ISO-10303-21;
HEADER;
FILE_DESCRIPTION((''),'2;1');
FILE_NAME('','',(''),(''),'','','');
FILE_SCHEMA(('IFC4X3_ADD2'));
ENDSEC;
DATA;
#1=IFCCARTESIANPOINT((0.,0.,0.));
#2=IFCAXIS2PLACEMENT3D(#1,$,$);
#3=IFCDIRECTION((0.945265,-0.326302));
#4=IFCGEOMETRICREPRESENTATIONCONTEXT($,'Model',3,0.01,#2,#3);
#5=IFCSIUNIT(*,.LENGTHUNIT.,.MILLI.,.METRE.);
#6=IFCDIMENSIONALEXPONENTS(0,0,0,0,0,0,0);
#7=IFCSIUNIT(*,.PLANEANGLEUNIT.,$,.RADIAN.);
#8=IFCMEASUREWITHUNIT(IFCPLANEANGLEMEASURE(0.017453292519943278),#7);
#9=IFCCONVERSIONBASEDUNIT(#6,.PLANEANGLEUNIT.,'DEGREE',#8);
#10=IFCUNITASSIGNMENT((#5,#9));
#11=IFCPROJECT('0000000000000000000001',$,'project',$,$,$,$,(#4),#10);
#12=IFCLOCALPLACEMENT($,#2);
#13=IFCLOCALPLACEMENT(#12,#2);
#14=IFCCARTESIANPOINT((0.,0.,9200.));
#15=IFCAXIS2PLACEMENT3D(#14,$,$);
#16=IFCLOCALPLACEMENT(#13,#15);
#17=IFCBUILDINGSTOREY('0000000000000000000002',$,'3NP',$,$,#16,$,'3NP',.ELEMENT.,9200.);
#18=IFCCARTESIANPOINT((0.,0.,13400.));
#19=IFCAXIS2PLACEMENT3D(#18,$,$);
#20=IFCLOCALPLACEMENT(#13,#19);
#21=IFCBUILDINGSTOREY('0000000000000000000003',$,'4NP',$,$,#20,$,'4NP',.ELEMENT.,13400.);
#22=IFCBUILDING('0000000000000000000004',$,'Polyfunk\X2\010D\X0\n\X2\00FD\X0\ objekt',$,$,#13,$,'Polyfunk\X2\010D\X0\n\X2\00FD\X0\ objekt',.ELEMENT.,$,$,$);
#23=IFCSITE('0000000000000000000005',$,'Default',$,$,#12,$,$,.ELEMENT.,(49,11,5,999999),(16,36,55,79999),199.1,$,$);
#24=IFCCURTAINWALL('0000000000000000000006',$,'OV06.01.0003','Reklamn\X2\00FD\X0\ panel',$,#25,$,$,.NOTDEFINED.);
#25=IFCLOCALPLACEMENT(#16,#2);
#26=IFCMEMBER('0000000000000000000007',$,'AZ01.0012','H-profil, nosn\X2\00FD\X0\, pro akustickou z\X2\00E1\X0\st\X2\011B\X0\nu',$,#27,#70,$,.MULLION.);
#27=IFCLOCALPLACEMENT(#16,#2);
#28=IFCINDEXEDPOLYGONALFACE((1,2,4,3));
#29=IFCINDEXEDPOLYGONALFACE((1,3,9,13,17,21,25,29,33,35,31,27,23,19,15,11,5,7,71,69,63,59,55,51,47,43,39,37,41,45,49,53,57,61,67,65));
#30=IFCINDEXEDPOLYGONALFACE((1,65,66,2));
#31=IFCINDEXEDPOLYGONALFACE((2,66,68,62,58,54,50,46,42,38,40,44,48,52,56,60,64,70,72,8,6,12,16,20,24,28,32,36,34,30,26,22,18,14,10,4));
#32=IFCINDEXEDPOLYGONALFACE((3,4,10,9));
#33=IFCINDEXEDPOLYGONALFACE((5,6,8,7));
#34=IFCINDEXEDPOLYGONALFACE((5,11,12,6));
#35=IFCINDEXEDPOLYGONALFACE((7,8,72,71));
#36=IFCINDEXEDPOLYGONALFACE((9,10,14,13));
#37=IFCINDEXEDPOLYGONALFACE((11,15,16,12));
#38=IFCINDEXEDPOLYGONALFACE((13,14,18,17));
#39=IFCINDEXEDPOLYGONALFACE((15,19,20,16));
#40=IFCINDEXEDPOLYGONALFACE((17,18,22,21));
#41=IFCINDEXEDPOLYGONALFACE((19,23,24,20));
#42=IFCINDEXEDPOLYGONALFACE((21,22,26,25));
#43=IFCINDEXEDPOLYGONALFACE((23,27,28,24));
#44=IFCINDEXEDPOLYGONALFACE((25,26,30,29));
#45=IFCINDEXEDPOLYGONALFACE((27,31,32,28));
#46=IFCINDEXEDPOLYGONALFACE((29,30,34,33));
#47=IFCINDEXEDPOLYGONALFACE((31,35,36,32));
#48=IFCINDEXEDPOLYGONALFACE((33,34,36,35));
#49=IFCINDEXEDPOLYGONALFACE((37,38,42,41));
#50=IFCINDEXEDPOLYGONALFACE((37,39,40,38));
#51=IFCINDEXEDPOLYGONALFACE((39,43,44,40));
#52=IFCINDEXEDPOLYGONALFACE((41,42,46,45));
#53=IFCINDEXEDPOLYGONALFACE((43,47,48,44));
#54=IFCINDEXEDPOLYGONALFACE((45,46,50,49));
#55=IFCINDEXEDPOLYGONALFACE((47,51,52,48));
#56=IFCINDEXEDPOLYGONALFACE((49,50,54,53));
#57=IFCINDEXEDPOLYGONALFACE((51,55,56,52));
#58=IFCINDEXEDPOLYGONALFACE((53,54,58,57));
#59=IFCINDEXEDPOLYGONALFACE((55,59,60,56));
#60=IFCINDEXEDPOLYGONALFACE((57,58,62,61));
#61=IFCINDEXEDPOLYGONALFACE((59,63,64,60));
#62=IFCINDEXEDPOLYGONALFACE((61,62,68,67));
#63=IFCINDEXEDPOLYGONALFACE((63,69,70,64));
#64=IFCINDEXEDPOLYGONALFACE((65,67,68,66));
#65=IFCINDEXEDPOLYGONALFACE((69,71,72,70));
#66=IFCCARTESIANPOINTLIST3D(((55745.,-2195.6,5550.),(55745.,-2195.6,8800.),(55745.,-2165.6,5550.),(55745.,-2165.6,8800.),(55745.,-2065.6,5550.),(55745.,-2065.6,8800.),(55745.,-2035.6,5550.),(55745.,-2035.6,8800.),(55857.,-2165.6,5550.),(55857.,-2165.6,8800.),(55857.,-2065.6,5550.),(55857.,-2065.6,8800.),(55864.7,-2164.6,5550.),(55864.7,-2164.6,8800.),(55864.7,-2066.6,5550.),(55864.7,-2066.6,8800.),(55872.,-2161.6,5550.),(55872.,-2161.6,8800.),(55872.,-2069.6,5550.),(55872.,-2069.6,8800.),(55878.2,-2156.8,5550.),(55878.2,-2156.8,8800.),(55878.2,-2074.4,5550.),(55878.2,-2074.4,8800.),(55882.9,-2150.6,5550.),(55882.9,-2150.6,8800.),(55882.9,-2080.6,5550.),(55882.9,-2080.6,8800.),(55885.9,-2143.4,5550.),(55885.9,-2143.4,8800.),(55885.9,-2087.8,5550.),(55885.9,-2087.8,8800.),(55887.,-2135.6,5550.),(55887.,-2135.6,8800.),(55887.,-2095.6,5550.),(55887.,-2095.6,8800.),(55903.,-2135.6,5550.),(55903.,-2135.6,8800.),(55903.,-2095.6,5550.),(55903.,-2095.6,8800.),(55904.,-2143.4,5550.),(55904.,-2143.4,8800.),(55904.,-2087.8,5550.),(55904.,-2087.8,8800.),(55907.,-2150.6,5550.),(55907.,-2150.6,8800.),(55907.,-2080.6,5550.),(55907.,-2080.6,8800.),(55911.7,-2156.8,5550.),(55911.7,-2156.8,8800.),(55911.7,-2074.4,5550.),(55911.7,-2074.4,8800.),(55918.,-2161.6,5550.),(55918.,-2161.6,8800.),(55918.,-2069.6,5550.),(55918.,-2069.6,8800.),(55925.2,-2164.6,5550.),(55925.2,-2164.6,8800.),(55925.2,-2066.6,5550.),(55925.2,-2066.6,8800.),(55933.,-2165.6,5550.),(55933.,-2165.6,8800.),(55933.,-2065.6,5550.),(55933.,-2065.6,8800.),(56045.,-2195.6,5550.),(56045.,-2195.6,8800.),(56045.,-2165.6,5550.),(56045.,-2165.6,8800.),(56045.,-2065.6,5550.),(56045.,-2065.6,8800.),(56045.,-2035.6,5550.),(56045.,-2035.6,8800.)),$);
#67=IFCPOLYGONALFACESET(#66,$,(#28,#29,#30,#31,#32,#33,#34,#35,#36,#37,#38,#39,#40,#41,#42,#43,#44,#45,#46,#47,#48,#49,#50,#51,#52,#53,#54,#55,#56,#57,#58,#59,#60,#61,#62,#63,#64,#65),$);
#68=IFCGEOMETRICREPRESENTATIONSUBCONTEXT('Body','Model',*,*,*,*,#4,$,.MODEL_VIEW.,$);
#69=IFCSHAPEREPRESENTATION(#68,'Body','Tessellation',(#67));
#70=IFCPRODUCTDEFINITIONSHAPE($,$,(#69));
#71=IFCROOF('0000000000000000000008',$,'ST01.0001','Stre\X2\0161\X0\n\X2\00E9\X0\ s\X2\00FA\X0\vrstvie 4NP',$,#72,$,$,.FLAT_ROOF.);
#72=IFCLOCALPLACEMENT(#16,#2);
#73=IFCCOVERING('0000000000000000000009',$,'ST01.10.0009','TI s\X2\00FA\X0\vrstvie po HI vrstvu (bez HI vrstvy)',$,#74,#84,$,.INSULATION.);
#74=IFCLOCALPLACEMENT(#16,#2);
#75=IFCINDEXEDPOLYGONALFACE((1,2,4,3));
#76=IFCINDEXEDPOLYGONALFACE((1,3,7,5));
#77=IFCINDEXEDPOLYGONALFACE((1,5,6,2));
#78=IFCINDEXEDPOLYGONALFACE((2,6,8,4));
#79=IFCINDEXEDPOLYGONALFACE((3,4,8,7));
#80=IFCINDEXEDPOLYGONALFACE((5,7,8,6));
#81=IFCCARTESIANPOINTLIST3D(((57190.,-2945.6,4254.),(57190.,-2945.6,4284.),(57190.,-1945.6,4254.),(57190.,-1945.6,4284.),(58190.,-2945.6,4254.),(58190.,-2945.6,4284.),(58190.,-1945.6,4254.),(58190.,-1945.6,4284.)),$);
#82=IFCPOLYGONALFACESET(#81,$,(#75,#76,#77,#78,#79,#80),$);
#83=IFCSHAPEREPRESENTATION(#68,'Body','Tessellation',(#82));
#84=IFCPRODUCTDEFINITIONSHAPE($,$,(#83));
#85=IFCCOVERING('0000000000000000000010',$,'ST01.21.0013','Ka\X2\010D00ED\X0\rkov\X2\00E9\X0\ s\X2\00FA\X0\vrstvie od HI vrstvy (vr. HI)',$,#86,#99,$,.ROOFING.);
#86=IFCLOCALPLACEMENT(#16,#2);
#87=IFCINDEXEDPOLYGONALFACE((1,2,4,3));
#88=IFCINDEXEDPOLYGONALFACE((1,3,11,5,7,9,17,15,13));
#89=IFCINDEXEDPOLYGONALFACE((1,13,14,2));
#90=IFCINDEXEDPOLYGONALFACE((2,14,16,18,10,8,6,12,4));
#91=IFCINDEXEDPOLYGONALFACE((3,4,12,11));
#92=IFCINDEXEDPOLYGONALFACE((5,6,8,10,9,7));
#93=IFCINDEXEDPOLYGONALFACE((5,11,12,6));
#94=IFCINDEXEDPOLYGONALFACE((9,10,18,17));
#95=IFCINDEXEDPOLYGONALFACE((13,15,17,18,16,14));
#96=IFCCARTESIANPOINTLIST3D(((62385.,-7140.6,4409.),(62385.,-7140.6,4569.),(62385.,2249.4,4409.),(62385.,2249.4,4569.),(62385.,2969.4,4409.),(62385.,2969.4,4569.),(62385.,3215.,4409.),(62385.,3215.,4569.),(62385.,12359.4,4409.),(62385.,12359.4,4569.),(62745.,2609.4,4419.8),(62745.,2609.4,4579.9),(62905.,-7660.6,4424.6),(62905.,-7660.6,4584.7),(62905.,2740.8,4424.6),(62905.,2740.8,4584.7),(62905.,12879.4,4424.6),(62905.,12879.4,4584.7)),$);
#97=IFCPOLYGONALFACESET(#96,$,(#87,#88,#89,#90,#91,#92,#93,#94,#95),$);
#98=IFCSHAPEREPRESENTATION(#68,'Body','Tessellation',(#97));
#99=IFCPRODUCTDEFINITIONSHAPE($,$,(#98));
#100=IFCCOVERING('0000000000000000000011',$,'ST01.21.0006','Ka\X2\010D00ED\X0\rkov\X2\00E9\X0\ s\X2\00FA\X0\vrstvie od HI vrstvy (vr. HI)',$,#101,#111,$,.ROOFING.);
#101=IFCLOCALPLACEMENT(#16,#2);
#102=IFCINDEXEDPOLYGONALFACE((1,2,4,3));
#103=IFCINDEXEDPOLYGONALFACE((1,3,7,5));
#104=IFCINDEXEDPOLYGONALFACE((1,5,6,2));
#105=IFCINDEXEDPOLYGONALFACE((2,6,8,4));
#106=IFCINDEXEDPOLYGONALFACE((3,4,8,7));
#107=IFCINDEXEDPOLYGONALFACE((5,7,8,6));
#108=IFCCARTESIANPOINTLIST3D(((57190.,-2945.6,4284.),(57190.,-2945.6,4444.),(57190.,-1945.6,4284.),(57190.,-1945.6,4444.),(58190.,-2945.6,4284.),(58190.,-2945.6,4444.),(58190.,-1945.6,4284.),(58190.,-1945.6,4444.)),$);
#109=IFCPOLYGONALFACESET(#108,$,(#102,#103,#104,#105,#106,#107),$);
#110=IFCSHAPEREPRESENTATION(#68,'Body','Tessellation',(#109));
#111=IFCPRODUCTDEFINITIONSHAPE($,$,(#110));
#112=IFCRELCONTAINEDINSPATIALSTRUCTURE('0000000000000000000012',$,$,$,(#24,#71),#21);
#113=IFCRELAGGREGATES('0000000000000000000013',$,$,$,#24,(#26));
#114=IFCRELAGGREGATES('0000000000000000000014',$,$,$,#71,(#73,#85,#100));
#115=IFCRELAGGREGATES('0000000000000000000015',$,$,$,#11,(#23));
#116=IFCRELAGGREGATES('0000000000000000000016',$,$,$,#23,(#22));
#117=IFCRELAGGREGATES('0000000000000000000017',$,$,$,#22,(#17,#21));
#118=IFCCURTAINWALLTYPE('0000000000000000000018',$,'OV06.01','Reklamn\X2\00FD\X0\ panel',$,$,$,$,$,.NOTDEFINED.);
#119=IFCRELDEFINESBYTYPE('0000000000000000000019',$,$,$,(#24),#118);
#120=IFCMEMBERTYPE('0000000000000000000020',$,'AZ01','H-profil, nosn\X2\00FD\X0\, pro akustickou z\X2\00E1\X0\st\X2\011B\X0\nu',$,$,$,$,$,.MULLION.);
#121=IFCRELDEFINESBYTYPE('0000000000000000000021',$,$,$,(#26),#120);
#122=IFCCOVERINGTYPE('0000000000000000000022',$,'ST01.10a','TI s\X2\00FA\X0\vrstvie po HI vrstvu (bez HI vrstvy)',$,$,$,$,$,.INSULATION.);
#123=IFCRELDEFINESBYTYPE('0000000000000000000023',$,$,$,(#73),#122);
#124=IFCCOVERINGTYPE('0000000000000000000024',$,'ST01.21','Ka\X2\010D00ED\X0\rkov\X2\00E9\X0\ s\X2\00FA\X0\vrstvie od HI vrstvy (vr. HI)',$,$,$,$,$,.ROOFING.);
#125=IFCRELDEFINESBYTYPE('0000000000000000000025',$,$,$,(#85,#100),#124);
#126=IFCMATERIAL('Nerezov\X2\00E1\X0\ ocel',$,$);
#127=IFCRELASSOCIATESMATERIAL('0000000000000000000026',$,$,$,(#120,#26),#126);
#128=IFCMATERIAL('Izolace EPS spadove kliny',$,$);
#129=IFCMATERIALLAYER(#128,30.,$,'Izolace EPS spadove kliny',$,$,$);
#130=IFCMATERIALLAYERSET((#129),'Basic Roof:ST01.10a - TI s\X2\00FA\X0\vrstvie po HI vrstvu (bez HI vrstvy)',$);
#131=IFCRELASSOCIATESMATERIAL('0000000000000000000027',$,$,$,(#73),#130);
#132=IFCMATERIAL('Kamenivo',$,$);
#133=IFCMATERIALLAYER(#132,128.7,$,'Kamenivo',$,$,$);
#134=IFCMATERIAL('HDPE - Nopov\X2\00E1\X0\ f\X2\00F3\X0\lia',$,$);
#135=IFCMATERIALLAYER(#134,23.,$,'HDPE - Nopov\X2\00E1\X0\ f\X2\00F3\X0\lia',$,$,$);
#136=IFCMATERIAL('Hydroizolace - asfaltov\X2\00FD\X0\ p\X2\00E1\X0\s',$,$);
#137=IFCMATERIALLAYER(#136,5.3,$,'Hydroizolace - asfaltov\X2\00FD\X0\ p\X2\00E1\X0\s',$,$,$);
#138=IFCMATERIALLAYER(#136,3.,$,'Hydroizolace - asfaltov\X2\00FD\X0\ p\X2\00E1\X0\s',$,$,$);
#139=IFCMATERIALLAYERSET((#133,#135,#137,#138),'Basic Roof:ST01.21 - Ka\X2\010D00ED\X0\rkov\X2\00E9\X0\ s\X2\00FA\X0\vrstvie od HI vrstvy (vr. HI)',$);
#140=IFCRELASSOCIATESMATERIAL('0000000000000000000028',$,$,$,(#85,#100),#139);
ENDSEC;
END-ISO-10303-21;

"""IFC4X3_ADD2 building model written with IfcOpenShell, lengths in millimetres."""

from ifc_helpers import new_model, entity, si_unit, converted_unit, direction, frame, frame_2d, origin, origin_2d_with_axis, place, context, subcontext, project, spatial, polyline, circle_curve, parameter, trimmed, segment, composite_curve, rectangle, outline, extrude, source, transform, mapped, material, layer, layer_set, material_profile, profile_set, profile_usage, type_object, element, aggregate, save


model = new_model("IFC4X3_ADD2")

# Units and contexts
model_context = context("Model", 3, precision=0.01, world=origin(), true_north=direction((0.945265, -0.326302)))
body_context = subcontext(model_context, "Body", "Model", "MODEL_VIEW")
ifc_project = project(units=[si_unit("LENGTHUNIT", "METRE", prefix="MILLI"), converted_unit("PLANEANGLEUNIT", "DEGREE", entity("IfcPlaneAngleMeasure", 0.017453292519943278), si_unit("PLANEANGLEUNIT", "RADIAN"), dimensions=[0, 0, 0, 0, 0, 0, 0])], contexts=[model_context])

# Site, building, storey
site_placement = place(None, origin())
site = spatial("IfcSite", under=ifc_project, at=site_placement, Name="Default", CompositionType="ELEMENT", RefLatitude=(49, 11, 5, 999999), RefLongitude=(16, 36, 55, 79999), RefElevation=199.1)
building_placement = place(site_placement, origin())
building = spatial("IfcBuilding", under=site, at=building_placement, Name="Polyfunkčný objekt", LongName="Polyfunkčný objekt", CompositionType="ELEMENT")
storey_1_placement = place(building_placement, frame((0.0, 0.0, 9200.0)))
storey_1 = spatial("IfcBuildingStorey", under=building, at=storey_1_placement, Name="3NP", LongName="3NP", CompositionType="ELEMENT", Elevation=9200.0)

# Shared definitions
storey_2_placement = place(building_placement, frame((0.0, 0.0, 13400.0)))
storey_2 = spatial("IfcBuildingStorey", under=building, at=storey_2_placement, Name="4NP", LongName="4NP", CompositionType="ELEMENT", Elevation=13400.0)

# Curtain wall, member
ifc_material_1 = material(Name="Nerezová ocel")
ifc_material_profile_1 = material_profile(ifc_material_1, outline(composite_curve([segment(polyline([(50.0, -150.0), (80.0, -150.0)]), True, "CONTINUOUS"), segment(polyline([(80.0, -150.0), (80.0, 150.0)]), True, "CONTINUOUS"), segment(polyline([(80.0, 150.0), (50.0, 150.0)]), True, "CONTINUOUS"), segment(polyline([(50.0, 150.0), (50.0, 38.0)]), True, "CONTINUOUS"), segment(trimmed(circle_curve(frame_2d((20.0, 38.0), x_axis=(0.0, 1.0)), 30.0), [parameter(180.0)], [parameter(270.0)], True, "PARAMETER"), False, "CONTINUOUS"), segment(polyline([(20.0, 8.0), (-20.0, 8.0)]), True, "CONTINUOUS"), segment(trimmed(circle_curve(frame_2d((-20.0, 38.0), x_axis=(0.0, 1.0)), 30.0), [parameter(90.0)], [parameter(180.0)], True, "PARAMETER"), False, "CONTINUOUS"), segment(polyline([(-50.0, 38.0), (-50.0, 150.0)]), True, "CONTINUOUS"), segment(polyline([(-50.0, 150.0), (-80.0, 150.0)]), True, "CONTINUOUS"), segment(polyline([(-80.0, 150.0), (-80.0, -150.0)]), True, "CONTINUOUS"), segment(polyline([(-80.0, -150.0), (-50.0, -150.0)]), True, "CONTINUOUS"), segment(polyline([(-50.0, -150.0), (-50.0, -38.0)]), True, "CONTINUOUS"), segment(trimmed(circle_curve(frame_2d((-20.0, -38.0), x_axis=(0.0, 1.0)), 30.0), [parameter(0.0)], [parameter(90.0)], True, "PARAMETER"), False, "CONTINUOUS"), segment(polyline([(-20.0, -8.0), (20.0, -8.0)]), True, "CONTINUOUS"), segment(trimmed(circle_curve(frame_2d((20.0, -38.0), x_axis=(0.0, 1.0)), 30.0), [parameter(270.0)], [parameter(0.0)], True, "PARAMETER"), False, "CONTINUOUS"), segment(polyline([(50.0, -38.0), (50.0, -150.0)]), True, "CONTINUOUS")], self_intersect=False)), Name="Profil zástena")
ifc_profile_set_1 = profile_set([ifc_material_profile_1], Name="Profil zástena")
ifc_profile_usage_1 = profile_usage(ifc_profile_set_1)
member_type_1 = type_object("IfcMemberType", Name="AZ01", Description="H-profil, nosný, pro akustickou zástěnu", PredefinedType="MULLION", material=ifc_profile_set_1)
curtain_wall_type_1 = type_object("IfcCurtainWallType", Name="OV06.01", Description="Reklamný panel", PredefinedType="NOTDEFINED")
curtain_wall_1_placement = place(storey_2_placement, frame((0.0, 0.0, -13400.0)))
curtain_wall_1 = element("IfcCurtainWall", 1, at=curtain_wall_1_placement, inside=storey_2, type_object=curtain_wall_type_1, Name="OV06.01.0003", Description="Reklamný panel", PredefinedType="NOTDEFINED")
shared_shape_1 = source(origin(), body_context, "Body", "SweptSolid", [
    extrude(outline(composite_curve([segment(polyline([(-150.0, -50.0), (-150.0, -80.0)]), True, "CONTINUOUS"), segment(polyline([(-150.0, -80.0), (150.0, -80.0)]), True, "CONTINUOUS"), segment(polyline([(150.0, -80.0), (150.0, -50.0)]), True, "CONTINUOUS"), segment(polyline([(150.0, -50.0), (38.0, -50.0)]), True, "CONTINUOUS"), segment(trimmed(circle_curve(frame_2d((38.0, -20.0), x_axis=(1.0, 0.0)), 30.0), [parameter(180.0)], [parameter(270.0)], True, "PARAMETER"), False, "CONTINUOUS"), segment(polyline([(8.0, -20.0), (8.0, 20.0)]), True, "CONTINUOUS"), segment(trimmed(circle_curve(frame_2d((38.0, 20.0), x_axis=(1.0, 0.0)), 30.0), [parameter(90.0)], [parameter(180.0)], True, "PARAMETER"), False, "CONTINUOUS"), segment(polyline([(38.0, 50.0), (150.0, 50.0)]), True, "CONTINUOUS"), segment(polyline([(150.0, 50.0), (150.0, 80.0)]), True, "CONTINUOUS"), segment(polyline([(150.0, 80.0), (-150.0, 80.0)]), True, "CONTINUOUS"), segment(polyline([(-150.0, 80.0), (-150.0, 50.0)]), True, "CONTINUOUS"), segment(polyline([(-150.0, 50.0), (-38.0, 50.0)]), True, "CONTINUOUS"), segment(trimmed(circle_curve(frame_2d((-38.0, 20.0), x_axis=(1.0, 0.0)), 30.0), [parameter(0.0)], [parameter(90.0)], True, "PARAMETER"), False, "CONTINUOUS"), segment(polyline([(-8.0, 20.0), (-8.0, -20.0)]), True, "CONTINUOUS"), segment(trimmed(circle_curve(frame_2d((-38.0, -20.0), x_axis=(1.0, 0.0)), 30.0), [parameter(270.0)], [parameter(0.0)], True, "PARAMETER"), False, "CONTINUOUS"), segment(polyline([(-38.0, -50.0), (-150.0, -50.0)]), True, "CONTINUOUS")], self_intersect=False)), frame((-150.0, 0.0, -3250.0), z_axis=(0.0, 0.0, -1.0), x_axis=(1.0, 0.0, 0.0)), (0.0, 0.0, -1.0), 3250.0),
])
member_1_placement = place(curtain_wall_1_placement, frame((56045.0, -2115.6, 14750.0), z_axis=(0.0, 0.0, -1.0), x_axis=(1.0, 0.0, 0.0)))
member_1 = element("IfcMember", 2, at=member_1_placement, type_object=member_type_1, material=ifc_profile_usage_1, Name="AZ01.0012", Description="H-profil, nosný, pro akustickou zástěnu", PredefinedType="MULLION", context=body_context, shape_type="MappedRepresentation", body=[
    mapped(shared_shape_1, transform((0.0, 0.0, 0.0), scale=1.0)),
])
aggregate(curtain_wall_1, [member_1])

# Roof, coverings
roof = element("IfcRoof", 3, inside=storey_2, Name="ST01.0001", Description="Strešné súvrstvie 4NP", PredefinedType="FLAT_ROOF")
ifc_material_2 = material(Name="Izolace EPS spadove kliny")
ifc_layer_1 = layer(ifc_material_2, 30.0, Name="Izolace EPS spadove kliny")
ifc_layer_set_1 = layer_set([ifc_layer_1], Name="Basic Roof:ST01.10a - TI súvrstvie po HI vrstvu (bez HI vrstvy)")
covering_type_1 = type_object("IfcCoveringType", Name="ST01.10a", Description="TI súvrstvie po HI vrstvu (bez HI vrstvy)", PredefinedType="INSULATION")
placement_1 = place(storey_2_placement, frame((57190.0, -2945.6, 54.0)))
covering_1_placement = place(placement_1, origin())
covering_1 = element("IfcCovering", 4, at=covering_1_placement, type_object=covering_type_1, material=ifc_layer_set_1, Name="ST01.10.0009", Description="TI súvrstvie po HI vrstvu (bez HI vrstvy)", PredefinedType="INSULATION", context=body_context, shape_type="SweptSolid", body=[
    extrude(rectangle(XDim=1000.0, YDim=1000.0, at=frame_2d((0.0, 0.0), x_axis=(-1.0, 0.0))), frame((500.0, 500.0, 0.0)), (0.0, 0.0, 1.0), 30.0),
])
ifc_material_3 = material(Name="HDPE - Nopová fólia")
ifc_material_4 = material(Name="Hydroizolace - asfaltový pás")
ifc_material_5 = material(Name="Kamenivo")
ifc_layer_2 = layer(ifc_material_5, 128.7, Name="Kamenivo")
ifc_layer_3 = layer(ifc_material_3, 23.0, Name="HDPE - Nopová fólia")
ifc_layer_4 = layer(ifc_material_4, 5.3, Name="Hydroizolace - asfaltový pás")
ifc_layer_5 = layer(ifc_material_4, 3.0, Name="Hydroizolace - asfaltový pás")
ifc_layer_set_2 = layer_set([ifc_layer_2, ifc_layer_3, ifc_layer_4, ifc_layer_5], Name="Basic Roof:ST01.21 - Kačírkové súvrstvie od HI vrstvy (vr. HI)")
covering_type_2 = type_object("IfcCoveringType", Name="ST01.21", Description="Kačírkové súvrstvie od HI vrstvy (vr. HI)", PredefinedType="ROOFING")
placement_2 = place(storey_2_placement, frame((62385.0, -7660.6, 209.0)))
covering_2_placement = place(placement_2, origin())
covering_2 = element("IfcCovering", 5, at=covering_2_placement, type_object=covering_type_2, material=ifc_layer_set_2, Name="ST01.21.0013", Description="Kačírkové súvrstvie od HI vrstvy (vr. HI)", PredefinedType="ROOFING", context=body_context, shape_type="SweptSolid", body=[
    extrude(outline(polyline([(-260.1, -9750.0), (260.1, -10270.0), (260.1, 131.4), (260.1, 10270.0), (-260.1, 9750.0), (-260.1, 605.6), (-260.1, 360.0), (100.0, 0.0), (-260.1, -360.0), (-260.1, -9750.0)])), frame((260.0, 10270.0, 7.8), z_axis=(-0.030015, 0.0, 0.999549), x_axis=(0.999549, 0.0, 0.030015)), (0.030015, 0.0, 0.999549), 160.1),
])
covering_3_placement = place(storey_2_placement, frame((57190.0, -2945.6, 84.0)))
covering_3 = element("IfcCovering", 6, at=covering_3_placement, type_object=covering_type_2, material=ifc_layer_set_2, Name="ST01.21.0006", Description="Kačírkové súvrstvie od HI vrstvy (vr. HI)", PredefinedType="ROOFING", context=body_context, shape_type="SweptSolid", body=[
    extrude(rectangle(XDim=1000.0, YDim=1000.0, at=origin_2d_with_axis()), frame((500.0, 500.0, 0.0), z_axis=(0.0, 0.0, 1.0), x_axis=(0.0, -1.0, 0.0)), (0.0, 0.0, 1.0), 160.0),
])
aggregate(roof, [covering_1, covering_2, covering_3])

save(model, "model.ifc")
